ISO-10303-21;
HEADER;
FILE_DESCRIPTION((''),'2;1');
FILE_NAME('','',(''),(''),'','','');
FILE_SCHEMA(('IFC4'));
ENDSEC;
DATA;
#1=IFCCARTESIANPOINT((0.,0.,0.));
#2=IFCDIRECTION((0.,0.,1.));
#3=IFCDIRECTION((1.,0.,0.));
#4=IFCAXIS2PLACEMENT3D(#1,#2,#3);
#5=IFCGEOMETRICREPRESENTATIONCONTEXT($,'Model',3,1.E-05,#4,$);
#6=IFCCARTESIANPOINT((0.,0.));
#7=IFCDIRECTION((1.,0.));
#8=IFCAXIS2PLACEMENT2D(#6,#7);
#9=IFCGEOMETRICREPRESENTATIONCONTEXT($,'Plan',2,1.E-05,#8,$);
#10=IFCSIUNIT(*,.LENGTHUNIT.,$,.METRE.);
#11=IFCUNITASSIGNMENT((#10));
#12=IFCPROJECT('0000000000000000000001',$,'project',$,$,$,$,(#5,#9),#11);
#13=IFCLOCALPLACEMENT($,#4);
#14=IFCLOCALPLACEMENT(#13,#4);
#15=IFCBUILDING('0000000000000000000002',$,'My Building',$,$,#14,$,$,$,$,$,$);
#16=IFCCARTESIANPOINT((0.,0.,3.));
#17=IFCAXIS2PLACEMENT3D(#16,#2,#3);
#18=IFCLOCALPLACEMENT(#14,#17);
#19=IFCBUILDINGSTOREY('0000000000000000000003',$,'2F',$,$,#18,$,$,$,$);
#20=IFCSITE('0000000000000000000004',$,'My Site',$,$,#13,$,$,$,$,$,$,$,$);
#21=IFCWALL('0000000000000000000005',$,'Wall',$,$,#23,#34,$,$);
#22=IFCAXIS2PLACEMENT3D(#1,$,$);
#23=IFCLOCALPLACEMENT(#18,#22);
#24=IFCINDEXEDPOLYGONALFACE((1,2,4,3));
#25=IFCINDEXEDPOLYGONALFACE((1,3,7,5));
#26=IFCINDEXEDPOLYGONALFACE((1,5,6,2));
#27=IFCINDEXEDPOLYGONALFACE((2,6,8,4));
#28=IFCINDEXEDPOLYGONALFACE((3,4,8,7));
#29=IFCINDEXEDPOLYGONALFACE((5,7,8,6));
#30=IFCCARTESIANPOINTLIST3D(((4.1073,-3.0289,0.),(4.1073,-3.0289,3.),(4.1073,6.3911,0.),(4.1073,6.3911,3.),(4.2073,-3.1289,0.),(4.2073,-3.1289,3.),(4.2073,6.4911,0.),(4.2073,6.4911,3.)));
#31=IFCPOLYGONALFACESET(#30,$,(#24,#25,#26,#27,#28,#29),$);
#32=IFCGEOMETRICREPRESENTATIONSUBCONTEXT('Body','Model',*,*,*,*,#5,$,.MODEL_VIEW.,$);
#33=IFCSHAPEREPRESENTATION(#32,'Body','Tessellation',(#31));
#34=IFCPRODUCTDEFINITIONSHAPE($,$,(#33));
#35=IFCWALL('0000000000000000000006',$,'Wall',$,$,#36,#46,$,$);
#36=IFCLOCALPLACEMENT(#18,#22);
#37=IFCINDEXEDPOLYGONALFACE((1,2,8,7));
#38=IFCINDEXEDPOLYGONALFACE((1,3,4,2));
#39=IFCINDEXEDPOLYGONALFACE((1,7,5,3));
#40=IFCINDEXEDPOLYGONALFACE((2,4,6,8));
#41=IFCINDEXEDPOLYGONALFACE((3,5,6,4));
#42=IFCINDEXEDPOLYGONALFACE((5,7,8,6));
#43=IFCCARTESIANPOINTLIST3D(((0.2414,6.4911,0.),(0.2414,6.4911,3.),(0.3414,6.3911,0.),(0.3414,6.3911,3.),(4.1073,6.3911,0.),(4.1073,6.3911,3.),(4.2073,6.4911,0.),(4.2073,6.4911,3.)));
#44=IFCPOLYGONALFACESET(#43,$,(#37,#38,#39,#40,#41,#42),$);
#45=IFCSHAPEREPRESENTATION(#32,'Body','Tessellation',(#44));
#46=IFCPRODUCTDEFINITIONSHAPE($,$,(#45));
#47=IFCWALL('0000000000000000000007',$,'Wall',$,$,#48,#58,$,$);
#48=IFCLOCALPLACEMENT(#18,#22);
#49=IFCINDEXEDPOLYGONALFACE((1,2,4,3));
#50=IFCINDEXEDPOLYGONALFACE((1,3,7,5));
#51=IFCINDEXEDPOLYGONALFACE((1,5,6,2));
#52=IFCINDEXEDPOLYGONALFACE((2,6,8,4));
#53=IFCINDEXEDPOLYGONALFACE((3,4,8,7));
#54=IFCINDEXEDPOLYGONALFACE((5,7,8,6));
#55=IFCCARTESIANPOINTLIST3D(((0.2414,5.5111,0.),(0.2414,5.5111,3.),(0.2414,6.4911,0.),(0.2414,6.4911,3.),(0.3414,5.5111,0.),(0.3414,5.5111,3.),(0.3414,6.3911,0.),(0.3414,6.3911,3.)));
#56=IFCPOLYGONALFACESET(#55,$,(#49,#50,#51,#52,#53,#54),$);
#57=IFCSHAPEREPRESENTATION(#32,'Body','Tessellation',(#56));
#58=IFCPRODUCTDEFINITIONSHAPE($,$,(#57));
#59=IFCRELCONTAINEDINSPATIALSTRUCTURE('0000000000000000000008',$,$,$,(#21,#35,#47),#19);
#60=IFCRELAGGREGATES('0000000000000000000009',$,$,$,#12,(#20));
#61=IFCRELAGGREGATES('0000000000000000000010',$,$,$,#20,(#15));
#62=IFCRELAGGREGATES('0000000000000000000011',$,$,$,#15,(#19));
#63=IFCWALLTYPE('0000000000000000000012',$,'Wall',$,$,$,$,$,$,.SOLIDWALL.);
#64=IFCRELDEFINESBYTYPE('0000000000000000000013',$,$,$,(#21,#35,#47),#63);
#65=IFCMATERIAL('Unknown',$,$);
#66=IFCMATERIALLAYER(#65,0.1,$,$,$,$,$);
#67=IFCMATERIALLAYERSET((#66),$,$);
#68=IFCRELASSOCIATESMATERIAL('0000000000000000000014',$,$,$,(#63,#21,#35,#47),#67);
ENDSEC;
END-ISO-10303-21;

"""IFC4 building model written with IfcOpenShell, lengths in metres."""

from ifc_helpers import new_model, si_unit, frame, origin_with_axes, origin_2d_with_axis, place, context, subcontext, project, spatial, line, indexed_curve, outline, extrude, material, layer, layer_set, layer_usage, type_object, element, save


model = new_model("IFC4")

# Units and contexts
model_context = context("Model", 3, precision=1e-05, world=origin_with_axes())
plan_context = context("Plan", 2, precision=1e-05, world=origin_2d_with_axis())
body_context_1 = subcontext(model_context, "Body", "Model", "MODEL_VIEW")
ifc_project = project(units=[si_unit("LENGTHUNIT", "METRE")], contexts=[model_context, plan_context])

# Site, building, storey
site_placement = place(None, origin_with_axes())
site = spatial("IfcSite", under=ifc_project, at=site_placement, Name="My Site")
building_placement = place(site_placement, origin_with_axes())
building = spatial("IfcBuilding", under=site, at=building_placement, Name="My Building")
storey_placement = place(building_placement, frame((0.0, 0.0, 3.0), z_axis=(0.0, 0.0, 1.0), x_axis=(1.0, 0.0, 0.0)))
storey = spatial("IfcBuildingStorey", under=building, at=storey_placement, Name="2F")

# Walls
ifc_material = material(Name="Unknown")
ifc_layer = layer(ifc_material, 0.1)
ifc_layer_set = layer_set([ifc_layer])
ifc_layer_usage_1 = layer_usage(ifc_layer_set, "AXIS2", "POSITIVE", 0.0)
wall_type = type_object("IfcWallType", Name="Wall", PredefinedType="SOLIDWALL", material=ifc_layer_set)
wall_1_placement = place(storey_placement, frame((4.2073, -3.1289, 0.0), z_axis=(0.0, 0.0, 1.0), x_axis=(0.0, 1.0, 0.0)))
element("IfcWall", 1, at=wall_1_placement, inside=storey, type_object=wall_type, material=ifc_layer_usage_1, Name="Wall", context=body_context_1, shape_type="SweptSolid", body=[
    extrude(outline(indexed_curve([(0.0, 0.0), (0.1, 0.1), (9.52, 0.1), (9.62, 0.0)], segments=[line(1, 2, 3, 4, 1)])), origin_with_axes(), (0.0, 0.0, 1.0), 3.0),
])
ifc_layer_usage_2 = layer_usage(ifc_layer_set, "AXIS2", "POSITIVE", 0.0)
wall_2_placement = place(storey_placement, frame((4.2073, 6.4911, 0.0), z_axis=(0.0, 0.0, 1.0), x_axis=(-1.0, 0.0, 0.0)))
element("IfcWall", 2, at=wall_2_placement, inside=storey, type_object=wall_type, material=ifc_layer_usage_2, Name="Wall", context=body_context_1, shape_type="SweptSolid", body=[
    extrude(outline(indexed_curve([(0.0, 0.0), (0.1, 0.1), (3.8658, 0.1), (3.9658, 0.0)], segments=[line(1, 2, 3, 4, 1)])), origin_with_axes(), (0.0, 0.0, 1.0), 3.0),
])
ifc_layer_usage_3 = layer_usage(ifc_layer_set, "AXIS2", "POSITIVE", 0.0)
wall_3_placement = place(storey_placement, frame((0.2414, 6.4911, 0.0), z_axis=(0.0, 0.0, 1.0), x_axis=(0.0, -1.0, 0.0)))
element("IfcWall", 3, at=wall_3_placement, inside=storey, type_object=wall_type, material=ifc_layer_usage_3, Name="Wall", context=body_context_1, shape_type="SweptSolid", body=[
    extrude(outline(indexed_curve([(0.0, 0.0), (0.1, 0.1), (0.98, 0.1), (0.98, 0.0)], segments=[line(1, 2, 3, 4, 1)])), origin_with_axes(), (0.0, 0.0, 1.0), 3.0),
])

save(model, "model.ifc")
